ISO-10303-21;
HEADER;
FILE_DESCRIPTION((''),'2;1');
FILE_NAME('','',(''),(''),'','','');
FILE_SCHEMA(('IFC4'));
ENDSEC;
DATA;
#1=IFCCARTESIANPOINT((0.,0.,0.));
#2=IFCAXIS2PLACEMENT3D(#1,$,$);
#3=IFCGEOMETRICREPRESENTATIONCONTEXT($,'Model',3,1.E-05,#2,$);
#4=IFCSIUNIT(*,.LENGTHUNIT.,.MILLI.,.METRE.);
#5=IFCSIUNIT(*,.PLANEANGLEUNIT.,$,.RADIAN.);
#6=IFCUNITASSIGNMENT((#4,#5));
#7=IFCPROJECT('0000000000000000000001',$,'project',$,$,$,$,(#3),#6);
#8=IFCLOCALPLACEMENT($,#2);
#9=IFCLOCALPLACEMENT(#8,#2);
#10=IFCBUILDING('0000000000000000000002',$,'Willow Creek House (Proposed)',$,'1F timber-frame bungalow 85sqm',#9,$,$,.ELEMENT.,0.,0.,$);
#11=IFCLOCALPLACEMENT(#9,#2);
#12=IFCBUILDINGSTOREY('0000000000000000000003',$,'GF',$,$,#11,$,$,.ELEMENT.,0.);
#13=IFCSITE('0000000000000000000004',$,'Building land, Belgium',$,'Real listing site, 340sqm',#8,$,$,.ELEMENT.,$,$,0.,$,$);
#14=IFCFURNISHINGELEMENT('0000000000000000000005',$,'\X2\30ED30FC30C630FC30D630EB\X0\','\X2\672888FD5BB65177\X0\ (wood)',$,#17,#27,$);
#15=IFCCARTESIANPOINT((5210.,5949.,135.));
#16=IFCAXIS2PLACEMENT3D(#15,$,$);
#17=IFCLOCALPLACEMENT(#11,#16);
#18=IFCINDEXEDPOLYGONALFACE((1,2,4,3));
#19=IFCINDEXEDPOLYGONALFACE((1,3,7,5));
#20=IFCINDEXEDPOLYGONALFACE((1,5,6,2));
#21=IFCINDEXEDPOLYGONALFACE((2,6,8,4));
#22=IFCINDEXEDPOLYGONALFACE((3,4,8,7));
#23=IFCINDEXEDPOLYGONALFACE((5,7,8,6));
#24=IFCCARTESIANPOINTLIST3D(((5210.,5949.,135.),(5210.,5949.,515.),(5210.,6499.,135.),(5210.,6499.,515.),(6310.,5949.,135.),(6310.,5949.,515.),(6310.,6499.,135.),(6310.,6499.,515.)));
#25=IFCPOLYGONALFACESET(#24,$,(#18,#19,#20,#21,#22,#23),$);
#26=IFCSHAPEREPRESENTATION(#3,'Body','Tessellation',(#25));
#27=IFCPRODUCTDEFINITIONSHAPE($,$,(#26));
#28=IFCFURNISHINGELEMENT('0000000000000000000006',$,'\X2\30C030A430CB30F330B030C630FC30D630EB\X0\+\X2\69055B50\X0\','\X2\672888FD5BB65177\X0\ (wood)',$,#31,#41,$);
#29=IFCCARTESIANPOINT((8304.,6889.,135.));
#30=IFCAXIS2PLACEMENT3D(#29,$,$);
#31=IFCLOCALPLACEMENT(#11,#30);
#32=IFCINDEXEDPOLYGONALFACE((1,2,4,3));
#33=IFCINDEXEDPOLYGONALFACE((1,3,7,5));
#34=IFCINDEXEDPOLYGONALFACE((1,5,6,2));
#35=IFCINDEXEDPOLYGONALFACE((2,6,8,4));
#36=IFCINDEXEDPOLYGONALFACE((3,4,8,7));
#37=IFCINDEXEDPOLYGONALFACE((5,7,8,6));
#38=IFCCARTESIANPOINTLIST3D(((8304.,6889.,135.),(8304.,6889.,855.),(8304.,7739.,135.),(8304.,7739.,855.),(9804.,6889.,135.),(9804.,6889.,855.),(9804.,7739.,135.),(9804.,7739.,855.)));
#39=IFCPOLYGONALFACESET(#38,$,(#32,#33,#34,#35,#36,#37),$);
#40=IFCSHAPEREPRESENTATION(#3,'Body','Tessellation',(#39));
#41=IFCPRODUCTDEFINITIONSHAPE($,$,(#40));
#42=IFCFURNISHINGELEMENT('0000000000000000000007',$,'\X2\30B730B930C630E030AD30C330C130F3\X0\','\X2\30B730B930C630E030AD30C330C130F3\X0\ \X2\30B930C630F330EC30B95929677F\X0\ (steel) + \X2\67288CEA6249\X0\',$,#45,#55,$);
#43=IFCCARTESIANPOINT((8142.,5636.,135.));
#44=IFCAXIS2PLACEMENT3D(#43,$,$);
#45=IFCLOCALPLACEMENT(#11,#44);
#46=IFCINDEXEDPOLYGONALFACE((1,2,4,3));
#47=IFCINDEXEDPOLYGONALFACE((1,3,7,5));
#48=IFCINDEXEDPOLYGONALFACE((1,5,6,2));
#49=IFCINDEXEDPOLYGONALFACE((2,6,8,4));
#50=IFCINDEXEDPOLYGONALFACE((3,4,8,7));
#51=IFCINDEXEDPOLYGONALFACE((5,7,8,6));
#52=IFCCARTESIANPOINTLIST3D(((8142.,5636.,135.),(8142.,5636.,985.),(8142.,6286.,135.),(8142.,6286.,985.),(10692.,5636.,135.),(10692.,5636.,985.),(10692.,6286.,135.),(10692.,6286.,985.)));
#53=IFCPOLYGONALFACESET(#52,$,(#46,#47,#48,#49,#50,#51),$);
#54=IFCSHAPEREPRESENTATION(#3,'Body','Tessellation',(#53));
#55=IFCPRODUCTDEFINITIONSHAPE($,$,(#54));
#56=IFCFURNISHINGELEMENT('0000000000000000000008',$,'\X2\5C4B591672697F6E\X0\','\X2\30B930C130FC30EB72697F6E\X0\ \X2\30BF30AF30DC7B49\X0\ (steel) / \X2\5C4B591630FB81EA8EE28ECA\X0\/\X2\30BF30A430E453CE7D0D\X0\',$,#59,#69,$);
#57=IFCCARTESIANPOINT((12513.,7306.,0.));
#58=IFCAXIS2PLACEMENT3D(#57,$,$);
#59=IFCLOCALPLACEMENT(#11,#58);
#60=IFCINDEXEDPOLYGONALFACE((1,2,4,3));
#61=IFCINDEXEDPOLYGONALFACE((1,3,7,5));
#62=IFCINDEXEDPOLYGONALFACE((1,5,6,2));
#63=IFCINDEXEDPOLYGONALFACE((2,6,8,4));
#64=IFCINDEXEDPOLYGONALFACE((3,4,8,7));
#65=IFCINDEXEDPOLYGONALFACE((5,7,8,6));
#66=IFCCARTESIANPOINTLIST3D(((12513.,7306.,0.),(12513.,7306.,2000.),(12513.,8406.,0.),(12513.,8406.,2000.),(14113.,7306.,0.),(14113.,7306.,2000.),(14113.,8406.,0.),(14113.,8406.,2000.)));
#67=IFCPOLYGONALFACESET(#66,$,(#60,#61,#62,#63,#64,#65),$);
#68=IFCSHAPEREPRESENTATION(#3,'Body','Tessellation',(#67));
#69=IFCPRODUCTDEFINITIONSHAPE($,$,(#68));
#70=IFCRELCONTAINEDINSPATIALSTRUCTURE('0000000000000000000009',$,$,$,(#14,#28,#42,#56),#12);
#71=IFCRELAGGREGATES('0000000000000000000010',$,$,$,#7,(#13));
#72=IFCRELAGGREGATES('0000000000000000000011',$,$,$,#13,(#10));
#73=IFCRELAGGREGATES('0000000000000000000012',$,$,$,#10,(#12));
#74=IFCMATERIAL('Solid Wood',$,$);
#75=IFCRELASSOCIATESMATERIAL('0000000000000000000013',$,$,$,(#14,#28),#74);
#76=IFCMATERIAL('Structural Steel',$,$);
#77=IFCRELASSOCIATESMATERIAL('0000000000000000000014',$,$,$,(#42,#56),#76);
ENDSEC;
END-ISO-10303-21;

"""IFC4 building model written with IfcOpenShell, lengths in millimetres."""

from ifc_helpers import new_model, si_unit, frame, frame_2d, origin, place, context, project, spatial, rectangle, extrude, material, element, save


model = new_model("IFC4")

# Units and contexts
model_context = context("Model", 3, precision=1e-05, world=origin())
ifc_project = project(units=[si_unit("LENGTHUNIT", "METRE", prefix="MILLI"), si_unit("PLANEANGLEUNIT", "RADIAN")], contexts=[model_context])

# Site, building, storey
site_placement = place(None, origin())
site = spatial("IfcSite", under=ifc_project, at=site_placement, Name="Building land, Belgium", ObjectType="Real listing site, 340sqm", CompositionType="ELEMENT", RefElevation=0.0)
building_placement = place(site_placement, origin())
building = spatial("IfcBuilding", under=site, at=building_placement, Name="Willow Creek House (Proposed)", ObjectType="1F timber-frame bungalow 85sqm", CompositionType="ELEMENT", ElevationOfRefHeight=0.0, ElevationOfTerrain=0.0)
storey_placement = place(building_placement, origin())
storey = spatial("IfcBuildingStorey", under=building, at=storey_placement, Name="GF", CompositionType="ELEMENT", Elevation=0.0)

# Shared definitions
ifc_material_1 = material(Name="Solid Wood")

# Shared definitions
ifc_material_2 = material(Name="Structural Steel")

# Furnishing elements
furnishing_1_placement = place(storey_placement, frame((5210.0, 5949.0, 135.0)))
element("IfcFurnishingElement", 1, at=furnishing_1_placement, inside=storey, material=ifc_material_1, Name="ローテーブル", Description="木製家具 (wood)", context=model_context, shape_type="SweptSolid", body=[
    extrude(rectangle(XDim=1100.0, YDim=550.0, at=frame_2d((550.0, 275.0))), frame((5210.0, 5949.0, 135.0)), (0.0, 0.0, 1.0), 380.0),
])
furnishing_2_placement = place(storey_placement, frame((8304.0, 6889.0, 135.0)))
element("IfcFurnishingElement", 2, at=furnishing_2_placement, inside=storey, material=ifc_material_1, Name="ダイニングテーブル+椅子", Description="木製家具 (wood)", context=model_context, shape_type="SweptSolid", body=[
    extrude(rectangle(XDim=1500.0, YDim=850.0, at=frame_2d((750.0, 425.0))), frame((8304.0, 6889.0, 135.0)), (0.0, 0.0, 1.0), 720.0),
])
furnishing_3_placement = place(storey_placement, frame((8142.0, 5636.0, 135.0)))
element("IfcFurnishingElement", 3, at=furnishing_3_placement, inside=storey, material=ifc_material_2, Name="システムキッチン", Description="システムキッチン ステンレス天板 (steel) + 木質扉", context=model_context, shape_type="SweptSolid", body=[
    extrude(rectangle(XDim=2550.0, YDim=650.0, at=frame_2d((1275.0, 325.0))), frame((8142.0, 5636.0, 135.0)), (0.0, 0.0, 1.0), 850.0),
])
furnishing_4_placement = place(storey_placement, frame((12513.0, 7306.0, 0.0)))
element("IfcFurnishingElement", 4, at=furnishing_4_placement, inside=storey, material=ifc_material_2, Name="屋外物置", Description="スチール物置 タクボ等 (steel) / 屋外・自転車/タイヤ収納", context=model_context, shape_type="SweptSolid", body=[
    extrude(rectangle(XDim=1600.0, YDim=1100.0, at=frame_2d((800.0, 550.0))), frame((12513.0, 7306.0, 0.0)), (0.0, 0.0, 1.0), 2000.0),
])

save(model, "model.ifc")
